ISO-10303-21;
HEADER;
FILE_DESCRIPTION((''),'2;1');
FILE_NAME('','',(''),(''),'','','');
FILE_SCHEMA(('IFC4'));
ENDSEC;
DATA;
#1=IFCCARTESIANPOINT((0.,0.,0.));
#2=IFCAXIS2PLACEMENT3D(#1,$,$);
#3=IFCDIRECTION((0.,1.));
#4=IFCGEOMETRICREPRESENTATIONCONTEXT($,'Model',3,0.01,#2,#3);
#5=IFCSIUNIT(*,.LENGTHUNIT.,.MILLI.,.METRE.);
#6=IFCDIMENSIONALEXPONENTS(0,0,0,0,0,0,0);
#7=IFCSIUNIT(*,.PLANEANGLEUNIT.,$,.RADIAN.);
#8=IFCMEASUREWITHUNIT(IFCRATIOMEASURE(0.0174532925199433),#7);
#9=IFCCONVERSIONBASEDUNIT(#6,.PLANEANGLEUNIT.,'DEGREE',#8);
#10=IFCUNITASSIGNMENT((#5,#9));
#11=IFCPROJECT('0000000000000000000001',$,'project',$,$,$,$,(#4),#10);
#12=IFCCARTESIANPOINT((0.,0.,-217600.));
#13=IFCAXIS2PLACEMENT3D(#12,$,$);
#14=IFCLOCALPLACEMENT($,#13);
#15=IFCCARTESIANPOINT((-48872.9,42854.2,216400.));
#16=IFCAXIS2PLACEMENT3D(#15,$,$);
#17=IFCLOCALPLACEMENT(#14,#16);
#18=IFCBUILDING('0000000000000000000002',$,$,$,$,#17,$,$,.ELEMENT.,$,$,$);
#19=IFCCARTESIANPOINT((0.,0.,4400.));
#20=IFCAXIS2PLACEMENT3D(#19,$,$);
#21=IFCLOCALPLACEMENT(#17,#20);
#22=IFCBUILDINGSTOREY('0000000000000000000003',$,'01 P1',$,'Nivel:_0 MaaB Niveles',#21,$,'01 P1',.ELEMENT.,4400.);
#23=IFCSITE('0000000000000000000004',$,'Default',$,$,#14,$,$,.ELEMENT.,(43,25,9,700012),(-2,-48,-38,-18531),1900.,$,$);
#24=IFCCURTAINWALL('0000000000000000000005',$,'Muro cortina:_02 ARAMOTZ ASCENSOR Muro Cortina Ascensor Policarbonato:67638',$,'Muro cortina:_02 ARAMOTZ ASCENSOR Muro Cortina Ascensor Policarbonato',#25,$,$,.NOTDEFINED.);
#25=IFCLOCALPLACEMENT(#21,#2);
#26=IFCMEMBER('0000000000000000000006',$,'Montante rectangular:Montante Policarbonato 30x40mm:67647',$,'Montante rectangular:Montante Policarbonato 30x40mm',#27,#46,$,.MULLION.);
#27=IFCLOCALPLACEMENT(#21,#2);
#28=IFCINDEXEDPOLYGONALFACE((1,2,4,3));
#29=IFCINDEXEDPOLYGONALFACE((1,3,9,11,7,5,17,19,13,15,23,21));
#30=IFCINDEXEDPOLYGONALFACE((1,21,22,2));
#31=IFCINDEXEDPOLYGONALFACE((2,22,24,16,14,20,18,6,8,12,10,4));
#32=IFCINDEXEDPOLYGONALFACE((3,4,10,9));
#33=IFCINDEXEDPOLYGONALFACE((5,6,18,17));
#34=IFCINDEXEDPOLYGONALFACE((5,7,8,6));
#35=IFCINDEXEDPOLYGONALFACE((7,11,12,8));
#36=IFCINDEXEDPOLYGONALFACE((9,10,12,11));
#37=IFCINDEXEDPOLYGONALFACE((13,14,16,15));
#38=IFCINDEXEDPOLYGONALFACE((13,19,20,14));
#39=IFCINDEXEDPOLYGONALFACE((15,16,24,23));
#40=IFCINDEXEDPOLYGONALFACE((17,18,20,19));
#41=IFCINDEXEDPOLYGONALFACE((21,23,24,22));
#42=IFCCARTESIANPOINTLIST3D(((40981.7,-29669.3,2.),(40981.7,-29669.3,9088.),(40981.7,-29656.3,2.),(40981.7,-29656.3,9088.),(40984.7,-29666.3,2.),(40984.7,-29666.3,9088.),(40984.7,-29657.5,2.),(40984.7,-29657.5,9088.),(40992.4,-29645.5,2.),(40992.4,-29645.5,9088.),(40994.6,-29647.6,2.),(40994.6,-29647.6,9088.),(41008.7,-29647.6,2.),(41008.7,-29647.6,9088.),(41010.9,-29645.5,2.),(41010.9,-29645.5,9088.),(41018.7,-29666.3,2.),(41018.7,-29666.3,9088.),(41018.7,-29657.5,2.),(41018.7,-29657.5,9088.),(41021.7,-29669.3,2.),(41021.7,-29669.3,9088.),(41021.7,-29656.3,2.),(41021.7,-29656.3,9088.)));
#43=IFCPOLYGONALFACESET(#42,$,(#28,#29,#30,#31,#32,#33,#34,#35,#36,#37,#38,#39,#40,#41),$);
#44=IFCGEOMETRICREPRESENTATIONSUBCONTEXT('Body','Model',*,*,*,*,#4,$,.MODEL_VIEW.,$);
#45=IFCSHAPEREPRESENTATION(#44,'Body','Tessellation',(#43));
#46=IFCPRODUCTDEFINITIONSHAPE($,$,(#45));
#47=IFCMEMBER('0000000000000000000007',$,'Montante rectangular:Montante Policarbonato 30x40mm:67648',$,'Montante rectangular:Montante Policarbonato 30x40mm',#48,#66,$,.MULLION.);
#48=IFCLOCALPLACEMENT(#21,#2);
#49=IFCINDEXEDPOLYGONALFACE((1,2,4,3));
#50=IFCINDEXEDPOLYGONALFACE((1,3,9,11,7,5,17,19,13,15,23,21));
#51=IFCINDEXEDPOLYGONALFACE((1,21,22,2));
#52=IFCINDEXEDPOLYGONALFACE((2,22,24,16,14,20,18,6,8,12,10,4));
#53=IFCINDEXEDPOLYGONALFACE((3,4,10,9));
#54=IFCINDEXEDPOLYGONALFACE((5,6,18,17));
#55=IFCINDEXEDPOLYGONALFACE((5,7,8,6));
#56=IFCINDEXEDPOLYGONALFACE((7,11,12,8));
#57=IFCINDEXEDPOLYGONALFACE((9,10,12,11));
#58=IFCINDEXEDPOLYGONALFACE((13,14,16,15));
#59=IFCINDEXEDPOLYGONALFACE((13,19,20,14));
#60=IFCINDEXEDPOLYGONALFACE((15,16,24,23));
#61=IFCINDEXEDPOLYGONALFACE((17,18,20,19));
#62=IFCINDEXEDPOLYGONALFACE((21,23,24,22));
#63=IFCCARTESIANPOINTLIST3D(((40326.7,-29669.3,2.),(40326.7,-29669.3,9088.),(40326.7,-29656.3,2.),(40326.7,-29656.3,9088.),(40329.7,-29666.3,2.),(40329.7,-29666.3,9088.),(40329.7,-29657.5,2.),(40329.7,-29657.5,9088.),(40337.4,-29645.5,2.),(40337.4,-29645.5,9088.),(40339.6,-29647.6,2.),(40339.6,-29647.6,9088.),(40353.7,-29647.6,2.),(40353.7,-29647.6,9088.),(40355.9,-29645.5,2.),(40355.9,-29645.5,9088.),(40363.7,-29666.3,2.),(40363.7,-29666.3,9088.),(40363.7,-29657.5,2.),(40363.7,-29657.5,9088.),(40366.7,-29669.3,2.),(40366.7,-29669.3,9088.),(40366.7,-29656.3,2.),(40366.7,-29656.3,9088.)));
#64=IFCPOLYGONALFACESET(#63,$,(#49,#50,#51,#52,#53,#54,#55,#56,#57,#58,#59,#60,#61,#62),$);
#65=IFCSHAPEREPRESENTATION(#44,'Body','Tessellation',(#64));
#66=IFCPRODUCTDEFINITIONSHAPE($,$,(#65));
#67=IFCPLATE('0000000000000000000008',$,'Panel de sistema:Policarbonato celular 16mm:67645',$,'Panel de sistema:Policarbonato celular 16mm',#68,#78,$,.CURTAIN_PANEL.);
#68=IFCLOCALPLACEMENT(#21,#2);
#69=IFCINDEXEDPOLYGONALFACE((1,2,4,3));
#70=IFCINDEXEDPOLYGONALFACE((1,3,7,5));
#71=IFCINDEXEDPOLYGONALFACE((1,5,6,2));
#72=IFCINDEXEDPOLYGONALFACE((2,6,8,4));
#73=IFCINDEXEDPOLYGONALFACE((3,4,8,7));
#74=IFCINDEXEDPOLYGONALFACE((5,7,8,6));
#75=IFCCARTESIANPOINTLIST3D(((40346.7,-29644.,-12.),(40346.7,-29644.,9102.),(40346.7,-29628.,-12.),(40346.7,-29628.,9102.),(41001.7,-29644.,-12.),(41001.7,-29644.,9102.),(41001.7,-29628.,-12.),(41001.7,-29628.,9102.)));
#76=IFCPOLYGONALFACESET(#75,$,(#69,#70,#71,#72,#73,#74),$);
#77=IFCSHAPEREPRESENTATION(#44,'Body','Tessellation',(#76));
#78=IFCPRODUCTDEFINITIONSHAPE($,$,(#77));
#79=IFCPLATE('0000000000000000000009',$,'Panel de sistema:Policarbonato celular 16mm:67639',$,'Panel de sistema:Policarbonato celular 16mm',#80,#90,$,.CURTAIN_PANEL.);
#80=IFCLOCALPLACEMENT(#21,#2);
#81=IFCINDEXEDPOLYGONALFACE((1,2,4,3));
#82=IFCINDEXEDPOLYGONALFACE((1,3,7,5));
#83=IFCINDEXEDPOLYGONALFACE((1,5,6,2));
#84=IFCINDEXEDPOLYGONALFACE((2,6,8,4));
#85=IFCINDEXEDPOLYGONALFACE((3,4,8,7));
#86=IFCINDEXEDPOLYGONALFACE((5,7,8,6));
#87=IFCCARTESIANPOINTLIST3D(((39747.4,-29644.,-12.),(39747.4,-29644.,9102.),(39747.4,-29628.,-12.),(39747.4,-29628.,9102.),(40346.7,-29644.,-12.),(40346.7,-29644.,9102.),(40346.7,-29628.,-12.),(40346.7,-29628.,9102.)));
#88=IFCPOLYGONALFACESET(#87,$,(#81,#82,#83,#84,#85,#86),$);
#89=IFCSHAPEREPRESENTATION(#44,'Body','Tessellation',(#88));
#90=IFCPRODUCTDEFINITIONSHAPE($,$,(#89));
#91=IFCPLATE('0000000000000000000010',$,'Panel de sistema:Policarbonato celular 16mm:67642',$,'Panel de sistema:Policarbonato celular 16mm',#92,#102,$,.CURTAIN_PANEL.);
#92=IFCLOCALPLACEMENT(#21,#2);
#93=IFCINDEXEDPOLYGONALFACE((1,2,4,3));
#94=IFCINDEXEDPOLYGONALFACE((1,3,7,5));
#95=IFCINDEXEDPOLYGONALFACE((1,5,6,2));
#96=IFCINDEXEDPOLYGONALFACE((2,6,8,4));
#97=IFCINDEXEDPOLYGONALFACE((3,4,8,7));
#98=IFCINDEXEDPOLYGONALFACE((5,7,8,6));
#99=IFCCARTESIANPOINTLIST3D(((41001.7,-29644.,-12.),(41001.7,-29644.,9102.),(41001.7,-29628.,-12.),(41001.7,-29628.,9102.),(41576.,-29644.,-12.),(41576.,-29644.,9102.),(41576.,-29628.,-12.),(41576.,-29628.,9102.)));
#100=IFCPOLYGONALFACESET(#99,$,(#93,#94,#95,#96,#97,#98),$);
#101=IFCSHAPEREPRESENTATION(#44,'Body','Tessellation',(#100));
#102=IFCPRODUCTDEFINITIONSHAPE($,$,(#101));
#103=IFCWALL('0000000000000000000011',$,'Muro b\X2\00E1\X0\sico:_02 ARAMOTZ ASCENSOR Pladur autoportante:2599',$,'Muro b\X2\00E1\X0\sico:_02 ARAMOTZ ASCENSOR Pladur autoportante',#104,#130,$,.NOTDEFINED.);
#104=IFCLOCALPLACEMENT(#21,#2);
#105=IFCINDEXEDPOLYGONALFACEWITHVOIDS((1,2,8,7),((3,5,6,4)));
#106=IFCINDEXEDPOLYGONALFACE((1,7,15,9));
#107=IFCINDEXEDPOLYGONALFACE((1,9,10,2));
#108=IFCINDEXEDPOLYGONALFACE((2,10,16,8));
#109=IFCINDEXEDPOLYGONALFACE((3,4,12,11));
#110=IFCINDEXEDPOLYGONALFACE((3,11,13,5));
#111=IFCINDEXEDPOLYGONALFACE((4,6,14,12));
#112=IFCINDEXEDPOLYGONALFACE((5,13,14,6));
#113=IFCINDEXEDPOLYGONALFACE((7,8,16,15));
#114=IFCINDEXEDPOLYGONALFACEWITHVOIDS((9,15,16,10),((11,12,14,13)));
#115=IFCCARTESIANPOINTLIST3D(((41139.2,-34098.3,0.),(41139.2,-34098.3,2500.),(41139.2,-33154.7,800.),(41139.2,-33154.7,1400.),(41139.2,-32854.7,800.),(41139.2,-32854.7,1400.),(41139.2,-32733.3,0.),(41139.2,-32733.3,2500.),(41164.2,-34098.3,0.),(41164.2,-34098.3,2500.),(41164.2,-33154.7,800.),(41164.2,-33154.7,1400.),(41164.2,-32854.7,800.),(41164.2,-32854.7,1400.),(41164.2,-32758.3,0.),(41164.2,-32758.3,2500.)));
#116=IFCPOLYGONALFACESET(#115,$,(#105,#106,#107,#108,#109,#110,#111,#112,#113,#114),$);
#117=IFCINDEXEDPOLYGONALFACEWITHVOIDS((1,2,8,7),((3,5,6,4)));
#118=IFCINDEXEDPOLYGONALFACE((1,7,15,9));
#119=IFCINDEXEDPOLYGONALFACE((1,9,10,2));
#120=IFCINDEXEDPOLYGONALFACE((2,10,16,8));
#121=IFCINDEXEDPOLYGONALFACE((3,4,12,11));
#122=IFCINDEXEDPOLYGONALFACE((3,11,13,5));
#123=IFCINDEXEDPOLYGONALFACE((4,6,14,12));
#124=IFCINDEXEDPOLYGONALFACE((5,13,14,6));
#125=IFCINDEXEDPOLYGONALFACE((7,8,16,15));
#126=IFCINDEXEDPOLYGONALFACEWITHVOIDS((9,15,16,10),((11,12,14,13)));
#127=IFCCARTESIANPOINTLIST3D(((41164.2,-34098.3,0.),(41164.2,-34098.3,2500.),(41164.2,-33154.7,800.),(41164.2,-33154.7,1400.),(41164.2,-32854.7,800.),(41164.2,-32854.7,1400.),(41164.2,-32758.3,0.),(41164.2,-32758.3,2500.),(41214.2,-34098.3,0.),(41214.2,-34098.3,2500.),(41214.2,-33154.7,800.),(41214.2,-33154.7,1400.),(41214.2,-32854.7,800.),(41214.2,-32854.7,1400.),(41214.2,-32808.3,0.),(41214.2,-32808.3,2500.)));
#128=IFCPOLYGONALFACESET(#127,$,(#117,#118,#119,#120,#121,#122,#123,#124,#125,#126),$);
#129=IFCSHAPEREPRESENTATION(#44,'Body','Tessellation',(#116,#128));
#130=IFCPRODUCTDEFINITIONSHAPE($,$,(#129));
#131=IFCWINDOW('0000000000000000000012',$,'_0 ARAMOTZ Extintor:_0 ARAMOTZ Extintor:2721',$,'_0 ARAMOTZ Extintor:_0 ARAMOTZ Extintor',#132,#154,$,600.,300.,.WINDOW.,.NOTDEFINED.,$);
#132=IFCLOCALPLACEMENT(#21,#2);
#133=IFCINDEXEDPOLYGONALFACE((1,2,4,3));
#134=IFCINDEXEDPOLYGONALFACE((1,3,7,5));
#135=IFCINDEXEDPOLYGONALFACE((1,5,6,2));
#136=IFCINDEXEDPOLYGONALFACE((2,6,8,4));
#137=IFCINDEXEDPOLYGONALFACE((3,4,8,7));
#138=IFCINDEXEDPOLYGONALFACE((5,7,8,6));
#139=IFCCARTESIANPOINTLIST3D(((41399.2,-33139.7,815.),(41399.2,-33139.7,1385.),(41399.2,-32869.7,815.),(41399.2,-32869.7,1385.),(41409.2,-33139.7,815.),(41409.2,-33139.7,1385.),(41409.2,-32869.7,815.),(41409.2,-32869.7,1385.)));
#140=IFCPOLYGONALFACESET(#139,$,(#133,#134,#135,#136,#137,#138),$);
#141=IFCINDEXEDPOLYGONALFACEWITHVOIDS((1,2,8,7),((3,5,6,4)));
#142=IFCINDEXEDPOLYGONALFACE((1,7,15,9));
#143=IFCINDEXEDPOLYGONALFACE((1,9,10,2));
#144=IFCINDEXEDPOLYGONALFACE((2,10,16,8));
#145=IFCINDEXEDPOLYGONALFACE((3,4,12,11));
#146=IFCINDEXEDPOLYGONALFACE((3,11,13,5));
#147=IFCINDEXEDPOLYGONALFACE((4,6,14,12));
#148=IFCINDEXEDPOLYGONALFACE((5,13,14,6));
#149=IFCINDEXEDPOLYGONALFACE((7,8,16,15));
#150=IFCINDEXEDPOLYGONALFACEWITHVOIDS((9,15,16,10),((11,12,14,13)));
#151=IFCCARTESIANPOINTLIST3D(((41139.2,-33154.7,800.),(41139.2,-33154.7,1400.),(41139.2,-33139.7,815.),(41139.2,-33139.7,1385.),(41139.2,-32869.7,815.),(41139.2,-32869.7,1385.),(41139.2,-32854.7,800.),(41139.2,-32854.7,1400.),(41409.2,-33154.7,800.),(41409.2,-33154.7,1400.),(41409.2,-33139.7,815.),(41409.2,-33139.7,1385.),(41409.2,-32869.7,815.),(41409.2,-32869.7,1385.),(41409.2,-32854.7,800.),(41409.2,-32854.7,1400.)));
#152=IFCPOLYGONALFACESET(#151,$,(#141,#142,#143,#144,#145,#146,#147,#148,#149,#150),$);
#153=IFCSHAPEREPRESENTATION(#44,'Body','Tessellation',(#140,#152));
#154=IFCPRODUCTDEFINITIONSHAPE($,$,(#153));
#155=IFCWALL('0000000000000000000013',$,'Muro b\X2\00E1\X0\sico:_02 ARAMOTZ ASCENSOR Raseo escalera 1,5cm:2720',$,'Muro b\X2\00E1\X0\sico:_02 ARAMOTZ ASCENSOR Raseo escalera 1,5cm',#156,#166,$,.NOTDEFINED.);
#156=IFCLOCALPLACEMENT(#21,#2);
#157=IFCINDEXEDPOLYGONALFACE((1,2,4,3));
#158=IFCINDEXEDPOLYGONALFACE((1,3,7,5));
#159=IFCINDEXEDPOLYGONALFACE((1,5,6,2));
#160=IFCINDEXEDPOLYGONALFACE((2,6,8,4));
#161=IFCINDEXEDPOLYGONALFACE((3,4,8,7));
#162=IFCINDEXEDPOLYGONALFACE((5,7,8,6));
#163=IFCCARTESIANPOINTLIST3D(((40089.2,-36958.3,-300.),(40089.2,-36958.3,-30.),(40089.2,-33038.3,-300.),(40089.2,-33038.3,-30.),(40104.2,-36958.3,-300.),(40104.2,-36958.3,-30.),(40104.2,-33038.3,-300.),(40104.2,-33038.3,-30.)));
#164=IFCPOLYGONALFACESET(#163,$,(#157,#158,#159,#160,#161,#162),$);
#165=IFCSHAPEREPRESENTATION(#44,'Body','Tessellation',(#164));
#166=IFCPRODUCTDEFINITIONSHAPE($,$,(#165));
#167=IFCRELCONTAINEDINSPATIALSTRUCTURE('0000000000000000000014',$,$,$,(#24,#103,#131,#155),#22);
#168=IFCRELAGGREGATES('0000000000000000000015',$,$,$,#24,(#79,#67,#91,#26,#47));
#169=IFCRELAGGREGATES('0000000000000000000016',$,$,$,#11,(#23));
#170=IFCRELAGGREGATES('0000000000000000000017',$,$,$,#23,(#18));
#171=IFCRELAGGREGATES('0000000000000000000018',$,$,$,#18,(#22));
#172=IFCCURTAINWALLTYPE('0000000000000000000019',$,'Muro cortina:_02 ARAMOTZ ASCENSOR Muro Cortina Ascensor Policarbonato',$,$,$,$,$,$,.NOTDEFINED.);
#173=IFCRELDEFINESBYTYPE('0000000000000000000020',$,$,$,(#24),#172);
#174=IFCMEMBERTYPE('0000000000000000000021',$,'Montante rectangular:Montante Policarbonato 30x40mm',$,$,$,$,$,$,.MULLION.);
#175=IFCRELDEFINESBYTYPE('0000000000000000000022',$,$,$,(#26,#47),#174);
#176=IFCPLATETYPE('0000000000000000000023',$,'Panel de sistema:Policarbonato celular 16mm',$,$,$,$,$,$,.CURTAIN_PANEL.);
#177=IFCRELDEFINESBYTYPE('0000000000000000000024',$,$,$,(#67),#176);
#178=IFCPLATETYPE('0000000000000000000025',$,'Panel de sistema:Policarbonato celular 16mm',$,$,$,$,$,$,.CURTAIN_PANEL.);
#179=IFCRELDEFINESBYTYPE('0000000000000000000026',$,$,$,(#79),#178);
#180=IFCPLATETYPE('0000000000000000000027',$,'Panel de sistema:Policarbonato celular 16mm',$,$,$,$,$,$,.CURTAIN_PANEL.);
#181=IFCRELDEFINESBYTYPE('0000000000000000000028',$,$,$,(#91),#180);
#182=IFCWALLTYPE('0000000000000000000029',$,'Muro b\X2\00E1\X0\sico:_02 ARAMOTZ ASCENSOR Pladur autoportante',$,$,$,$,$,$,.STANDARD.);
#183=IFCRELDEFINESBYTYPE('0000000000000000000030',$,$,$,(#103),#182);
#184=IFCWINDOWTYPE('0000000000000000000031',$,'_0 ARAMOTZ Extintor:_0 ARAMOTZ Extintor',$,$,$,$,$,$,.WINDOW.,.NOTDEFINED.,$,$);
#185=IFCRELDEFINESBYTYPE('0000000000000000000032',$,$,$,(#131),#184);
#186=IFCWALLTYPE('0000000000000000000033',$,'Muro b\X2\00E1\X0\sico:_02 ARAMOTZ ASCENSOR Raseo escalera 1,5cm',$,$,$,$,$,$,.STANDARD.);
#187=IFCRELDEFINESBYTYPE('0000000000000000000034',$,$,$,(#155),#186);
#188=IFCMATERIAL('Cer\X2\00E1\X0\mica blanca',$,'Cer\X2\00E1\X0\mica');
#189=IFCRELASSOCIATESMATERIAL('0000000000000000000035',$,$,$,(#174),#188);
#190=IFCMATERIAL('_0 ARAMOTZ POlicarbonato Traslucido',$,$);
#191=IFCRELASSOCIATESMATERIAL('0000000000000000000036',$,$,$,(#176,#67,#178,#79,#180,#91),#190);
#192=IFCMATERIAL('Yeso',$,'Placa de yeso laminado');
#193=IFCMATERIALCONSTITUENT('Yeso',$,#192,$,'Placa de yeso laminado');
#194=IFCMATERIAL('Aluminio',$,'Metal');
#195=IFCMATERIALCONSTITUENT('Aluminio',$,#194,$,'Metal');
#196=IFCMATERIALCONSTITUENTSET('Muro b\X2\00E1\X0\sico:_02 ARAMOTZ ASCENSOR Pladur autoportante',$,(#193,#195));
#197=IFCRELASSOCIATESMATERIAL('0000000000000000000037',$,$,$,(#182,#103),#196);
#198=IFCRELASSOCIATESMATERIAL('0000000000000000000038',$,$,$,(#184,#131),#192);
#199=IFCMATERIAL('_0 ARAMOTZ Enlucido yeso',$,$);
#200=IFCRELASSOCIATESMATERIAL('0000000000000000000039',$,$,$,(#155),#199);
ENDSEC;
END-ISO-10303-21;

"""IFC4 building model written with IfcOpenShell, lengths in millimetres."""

from ifc_helpers import new_model, entity, si_unit, converted_unit, direction, frame, origin, place, context, subcontext, project, spatial, indexed_curve, outline, extrude, source, transform, mapped, material, constituent, constituent_set, type_object, type_shapes, element, fill, aggregate, save


model = new_model("IFC4")

# Units and contexts
model_context = context("Model", 3, precision=0.01, world=origin(), true_north=direction((0.0, 1.0)))
body_context = subcontext(model_context, "Body", "Model", "MODEL_VIEW")
ifc_project = project(units=[si_unit("LENGTHUNIT", "METRE", prefix="MILLI"), converted_unit("PLANEANGLEUNIT", "DEGREE", entity("IfcRatioMeasure", 0.0174532925199433), si_unit("PLANEANGLEUNIT", "RADIAN"), dimensions=[0, 0, 0, 0, 0, 0, 0])], contexts=[model_context])

# Site, building, storey
site_placement = place(None, frame((0.0, 0.0, -217600.0)))
site = spatial("IfcSite", under=ifc_project, at=site_placement, Name="Default", CompositionType="ELEMENT", RefLatitude=(43, 25, 9, 700012), RefLongitude=(-2, -48, -38, -18531), RefElevation=1900.0)
building_placement = place(site_placement, frame((-48872.9, 42854.2, 216400.0)))
building = spatial("IfcBuilding", under=site, at=building_placement, CompositionType="ELEMENT")
storey_placement = place(building_placement, frame((0.0, 0.0, 4400.0)))
storey = spatial("IfcBuildingStorey", under=building, at=storey_placement, Name="01 P1", ObjectType="Nivel:_0 MaaB Niveles", LongName="01 P1", CompositionType="ELEMENT", Elevation=4400.0)

# Shared definitions
ifc_material_1 = material(Name="Cerámica blanca", Category="Cerámica")

# Curtain wall, members
curtain_wall_type_1 = type_object("IfcCurtainWallType", Name="Muro cortina:_02 ARAMOTZ ASCENSOR Muro Cortina Ascensor Policarbonato", PredefinedType="NOTDEFINED")
curtain_wall_1_placement = place(storey_placement, frame((0.0, 0.0, -4400.0)))
curtain_wall_1 = element("IfcCurtainWall", 1, at=curtain_wall_1_placement, inside=storey, type_object=curtain_wall_type_1, Name="Muro cortina:_02 ARAMOTZ ASCENSOR Muro Cortina Ascensor Policarbonato:67638", ObjectType="Muro cortina:_02 ARAMOTZ ASCENSOR Muro Cortina Ascensor Policarbonato", PredefinedType="NOTDEFINED")
member_type_1 = type_object("IfcMemberType", Name="Montante rectangular:Montante Policarbonato 30x40mm", PredefinedType="MULLION", material=ifc_material_1)
shared_shape_1 = source(origin(), body_context, "Body", "SweptSolid", [
    extrude(outline(indexed_curve([(-12.2, -20.0), (0.8, -20.0), (11.6, -9.2), (9.5, -7.1), (-0.4, -17.0), (-9.2, -17.0), (-9.2, 17.0), (-0.4, 17.0), (9.5, 7.1), (11.6, 9.2), (0.8, 20.0), (-12.2, 20.0), (-12.2, -20.0)], self_intersect=False)), frame((0.0, 29.1, -9086.0), z_axis=(0.0, 0.0, 1.0), x_axis=(0.0, -1.0, 0.0)), (0.0, 0.0, 1.0), 9086.0),
])
type_shapes(member_type_1, [shared_shape_1])
member_1_placement = place(curtain_wall_1_placement, frame((41001.7, -29628.0, 4402.0), z_axis=(0.0, 0.0, -1.0), x_axis=(1.0, 0.0, 0.0)))
member_1 = element("IfcMember", 2, at=member_1_placement, type_object=member_type_1, Name="Montante rectangular:Montante Policarbonato 30x40mm:67647", ObjectType="Montante rectangular:Montante Policarbonato 30x40mm", PredefinedType="MULLION", context=body_context, shape_type="MappedRepresentation", body=[
    mapped(shared_shape_1, transform((0.0, 0.0, 0.0), scale=1.0)),
])
member_2_placement = place(curtain_wall_1_placement, frame((40346.7, -29628.0, 4402.0), z_axis=(0.0, 0.0, -1.0), x_axis=(1.0, 0.0, 0.0)))
member_2 = element("IfcMember", 3, at=member_2_placement, type_object=member_type_1, Name="Montante rectangular:Montante Policarbonato 30x40mm:67648", ObjectType="Montante rectangular:Montante Policarbonato 30x40mm", PredefinedType="MULLION", context=body_context, shape_type="MappedRepresentation", body=[
    mapped(shared_shape_1, transform((0.0, 0.0, 0.0), scale=1.0)),
])

# Plates
ifc_material_2 = material(Name="_0 ARAMOTZ POlicarbonato Traslucido")
plate_type_1 = type_object("IfcPlateType", Name="Panel de sistema:Policarbonato celular 16mm", PredefinedType="CURTAIN_PANEL", material=ifc_material_2)
shared_shape_2 = source(origin(), body_context, "Body", "SweptSolid", [
    extrude(outline(indexed_curve([(-8.0, -327.5), (8.0, -327.5), (8.0, 327.5), (-8.0, 327.5), (-8.0, -327.5)], self_intersect=False)), frame((0.0, -8.0, 0.0), z_axis=(0.0, 0.0, 1.0), x_axis=(0.0, 1.0, 0.0)), (0.0, 0.0, 1.0), 9114.0),
])
type_shapes(plate_type_1, [shared_shape_2])
plate_1_placement = place(curtain_wall_1_placement, frame((40674.2, -29628.0, 4388.0)))
plate_1 = element("IfcPlate", 4, at=plate_1_placement, type_object=plate_type_1, material=ifc_material_2, Name="Panel de sistema:Policarbonato celular 16mm:67645", ObjectType="Panel de sistema:Policarbonato celular 16mm", PredefinedType="CURTAIN_PANEL", context=body_context, shape_type="MappedRepresentation", body=[
    mapped(shared_shape_2, transform((0.0, 0.0, 0.0), scale=1.0)),
])
plate_type_2 = type_object("IfcPlateType", Name="Panel de sistema:Policarbonato celular 16mm", PredefinedType="CURTAIN_PANEL", material=ifc_material_2)
shared_shape_3 = source(origin(), body_context, "Body", "SweptSolid", [
    extrude(outline(indexed_curve([(-8.0, -299.6), (8.0, -299.6), (8.0, 299.6), (-8.0, 299.6), (-8.0, -299.6)], self_intersect=False)), frame((0.0, -8.0, 0.0), z_axis=(0.0, 0.0, 1.0), x_axis=(0.0, 1.0, 0.0)), (0.0, 0.0, 1.0), 9114.0),
])
type_shapes(plate_type_2, [shared_shape_3])
plate_2_placement = place(curtain_wall_1_placement, frame((40047.0, -29628.0, 4388.0)))
plate_2 = element("IfcPlate", 5, at=plate_2_placement, type_object=plate_type_2, material=ifc_material_2, Name="Panel de sistema:Policarbonato celular 16mm:67639", ObjectType="Panel de sistema:Policarbonato celular 16mm", PredefinedType="CURTAIN_PANEL", context=body_context, shape_type="MappedRepresentation", body=[
    mapped(shared_shape_3, transform((0.0, 0.0, 0.0), scale=1.0)),
])
plate_type_3 = type_object("IfcPlateType", Name="Panel de sistema:Policarbonato celular 16mm", PredefinedType="CURTAIN_PANEL", material=ifc_material_2)
shared_shape_4 = source(origin(), body_context, "Body", "SweptSolid", [
    extrude(outline(indexed_curve([(-8.0, -287.2), (8.0, -287.2), (8.0, 287.2), (-8.0, 287.2), (-8.0, -287.2)], self_intersect=False)), frame((0.0, -8.0, 0.0), z_axis=(0.0, 0.0, 1.0), x_axis=(0.0, 1.0, 0.0)), (0.0, 0.0, 1.0), 9114.0),
])
type_shapes(plate_type_3, [shared_shape_4])
plate_3_placement = place(curtain_wall_1_placement, frame((41288.8, -29628.0, 4388.0)))
plate_3 = element("IfcPlate", 6, at=plate_3_placement, type_object=plate_type_3, material=ifc_material_2, Name="Panel de sistema:Policarbonato celular 16mm:67642", ObjectType="Panel de sistema:Policarbonato celular 16mm", PredefinedType="CURTAIN_PANEL", context=body_context, shape_type="MappedRepresentation", body=[
    mapped(shared_shape_4, transform((0.0, 0.0, 0.0), scale=1.0)),
])

# Wall, opening, window
ifc_material_3 = material(Name="Yeso", Category="Placa de yeso laminado")
ifc_constituent_1 = constituent(ifc_material_3, Name="Yeso", Category="Placa de yeso laminado")
ifc_material_4 = material(Name="Aluminio", Category="Metal")
ifc_constituent_2 = constituent(ifc_material_4, Name="Aluminio", Category="Metal")
ifc_constituent_set_1 = constituent_set(constituents=[ifc_constituent_1, ifc_constituent_2], Name="Muro básico:_02 ARAMOTZ ASCENSOR Pladur autoportante")
wall_type_1 = type_object("IfcWallType", Name="Muro básico:_02 ARAMOTZ ASCENSOR Pladur autoportante", PredefinedType="STANDARD", material=ifc_constituent_set_1)
wall_1_placement = place(storey_placement, frame((41176.7, -34098.3, 0.0), z_axis=(0.0, 0.0, 1.0), x_axis=(0.0, 1.0, 0.0)))
wall_1 = element("IfcWall", 7, at=wall_1_placement, inside=storey, type_object=wall_type_1, material=ifc_constituent_set_1, Name="Muro básico:_02 ARAMOTZ ASCENSOR Pladur autoportante:2599", ObjectType="Muro básico:_02 ARAMOTZ ASCENSOR Pladur autoportante", PredefinedType="NOTDEFINED", context=body_context, shape_type="SweptSolid", body=[
    extrude(outline(indexed_curve([(-13.0, -541.0), (2.0, -541.0), (12.0, -541.0), (12.0, 799.0), (-13.0, 824.0), (-13.0, -541.0)], self_intersect=False)), frame((541.0, 24.5, 0.0), z_axis=(0.0, 0.0, 1.0), x_axis=(0.0, -1.0, 0.0)), (0.0, 0.0, 1.0), 2500.0),
    extrude(outline(indexed_curve([(-25.0, -657.5), (25.0, -657.5), (25.0, 632.5), (-25.0, 682.5), (-25.0, -657.5)], self_intersect=False)), frame((657.5, -12.5, 0.0), z_axis=(0.0, 0.0, 1.0), x_axis=(0.0, -1.0, 0.0)), (0.0, 0.0, 1.0), 2500.0),
])
opening_placement = place(wall_1_placement, frame((1243.6, 37.5, 800.0)))
opening = element("IfcOpeningElement", 8, at=opening_placement, cuts=wall_1, PredefinedType="OPENING", context=body_context, shape_type="SweptSolid", body=[
    extrude(outline(indexed_curve([(0.0, 0.0), (600.0, 0.0), (600.0, 300.0), (0.0, 300.0), (0.0, 0.0)], self_intersect=False)), frame((0.0, 0.0, 0.0), z_axis=(0.0, -1.0, 0.0), x_axis=(0.0, 0.0, 1.0)), (0.0, 0.0, 1.0), 75.0),
])
window_type = type_object("IfcWindowType", Name="_0 ARAMOTZ Extintor:_0 ARAMOTZ Extintor", PartitioningType="NOTDEFINED", PredefinedType="WINDOW", material=ifc_material_3)
shared_shape_5 = source(origin(), body_context, "Body", "SweptSolid", [
    extrude(outline(indexed_curve([(-5.0, -135.0), (5.0, -135.0), (5.0, 135.0), (-5.0, 135.0), (-5.0, -135.0)], self_intersect=False)), frame((150.0, 265.0, 15.0), z_axis=(0.0, 0.0, 1.0), x_axis=(0.0, -1.0, 0.0)), (0.0, 0.0, 1.0), 570.0),
    extrude(outline(indexed_curve([(-150.0, -300.0), (150.0, -300.0), (150.0, 300.0), (-150.0, 300.0), (-150.0, -300.0)], self_intersect=False), holes=[indexed_curve([(135.0, -285.0), (-135.0, -285.0), (-135.0, 285.0), (135.0, 285.0), (135.0, -285.0)], self_intersect=False)]), frame((150.0, 0.0, 300.0), z_axis=(0.0, 1.0, 0.0), x_axis=(1.0, 0.0, 0.0)), (0.0, 0.0, 1.0), 270.0),
])
type_shapes(window_type, [shared_shape_5])
window_placement = place(opening_placement, frame((0.0, 0.0, 0.0), z_axis=(0.0, 0.0, 1.0), x_axis=(-1.0, 0.0, 0.0)))
window = element("IfcWindow", 9, at=window_placement, inside=storey, type_object=window_type, material=ifc_material_3, Name="_0 ARAMOTZ Extintor:_0 ARAMOTZ Extintor:2721", ObjectType="_0 ARAMOTZ Extintor:_0 ARAMOTZ Extintor", OverallHeight=600.0, OverallWidth=300.0, PartitioningType="NOTDEFINED", PredefinedType="WINDOW", context=body_context, shape_type="MappedRepresentation", body=[
    mapped(shared_shape_5, transform((0.0, 0.0, 0.0), scale=1.0)),
])
fill(opening, window)

# Wall
ifc_material_5 = material(Name="_0 ARAMOTZ Enlucido yeso")
wall_type_2 = type_object("IfcWallType", Name="Muro básico:_02 ARAMOTZ ASCENSOR Raseo escalera 1,5cm", PredefinedType="STANDARD")
wall_2_placement = place(storey_placement, frame((40096.7, -36958.3, -300.0), z_axis=(0.0, 0.0, 1.0), x_axis=(0.0, 1.0, 0.0)))
element("IfcWall", 10, at=wall_2_placement, inside=storey, type_object=wall_type_2, material=ifc_material_5, Name="Muro básico:_02 ARAMOTZ ASCENSOR Raseo escalera 1,5cm:2720", ObjectType="Muro básico:_02 ARAMOTZ ASCENSOR Raseo escalera 1,5cm", PredefinedType="NOTDEFINED", context=body_context, shape_type="SweptSolid", body=[
    extrude(outline(indexed_curve([(3920.0, 7.5), (0.0, 7.5), (0.0, -7.5), (3920.0, -7.5), (3920.0, 7.5)], self_intersect=False)), origin(), (0.0, 0.0, 1.0), 270.0),
])

aggregate(curtain_wall_1, [plate_2, plate_1, plate_3, member_1, member_2])

save(model, "model.ifc")
